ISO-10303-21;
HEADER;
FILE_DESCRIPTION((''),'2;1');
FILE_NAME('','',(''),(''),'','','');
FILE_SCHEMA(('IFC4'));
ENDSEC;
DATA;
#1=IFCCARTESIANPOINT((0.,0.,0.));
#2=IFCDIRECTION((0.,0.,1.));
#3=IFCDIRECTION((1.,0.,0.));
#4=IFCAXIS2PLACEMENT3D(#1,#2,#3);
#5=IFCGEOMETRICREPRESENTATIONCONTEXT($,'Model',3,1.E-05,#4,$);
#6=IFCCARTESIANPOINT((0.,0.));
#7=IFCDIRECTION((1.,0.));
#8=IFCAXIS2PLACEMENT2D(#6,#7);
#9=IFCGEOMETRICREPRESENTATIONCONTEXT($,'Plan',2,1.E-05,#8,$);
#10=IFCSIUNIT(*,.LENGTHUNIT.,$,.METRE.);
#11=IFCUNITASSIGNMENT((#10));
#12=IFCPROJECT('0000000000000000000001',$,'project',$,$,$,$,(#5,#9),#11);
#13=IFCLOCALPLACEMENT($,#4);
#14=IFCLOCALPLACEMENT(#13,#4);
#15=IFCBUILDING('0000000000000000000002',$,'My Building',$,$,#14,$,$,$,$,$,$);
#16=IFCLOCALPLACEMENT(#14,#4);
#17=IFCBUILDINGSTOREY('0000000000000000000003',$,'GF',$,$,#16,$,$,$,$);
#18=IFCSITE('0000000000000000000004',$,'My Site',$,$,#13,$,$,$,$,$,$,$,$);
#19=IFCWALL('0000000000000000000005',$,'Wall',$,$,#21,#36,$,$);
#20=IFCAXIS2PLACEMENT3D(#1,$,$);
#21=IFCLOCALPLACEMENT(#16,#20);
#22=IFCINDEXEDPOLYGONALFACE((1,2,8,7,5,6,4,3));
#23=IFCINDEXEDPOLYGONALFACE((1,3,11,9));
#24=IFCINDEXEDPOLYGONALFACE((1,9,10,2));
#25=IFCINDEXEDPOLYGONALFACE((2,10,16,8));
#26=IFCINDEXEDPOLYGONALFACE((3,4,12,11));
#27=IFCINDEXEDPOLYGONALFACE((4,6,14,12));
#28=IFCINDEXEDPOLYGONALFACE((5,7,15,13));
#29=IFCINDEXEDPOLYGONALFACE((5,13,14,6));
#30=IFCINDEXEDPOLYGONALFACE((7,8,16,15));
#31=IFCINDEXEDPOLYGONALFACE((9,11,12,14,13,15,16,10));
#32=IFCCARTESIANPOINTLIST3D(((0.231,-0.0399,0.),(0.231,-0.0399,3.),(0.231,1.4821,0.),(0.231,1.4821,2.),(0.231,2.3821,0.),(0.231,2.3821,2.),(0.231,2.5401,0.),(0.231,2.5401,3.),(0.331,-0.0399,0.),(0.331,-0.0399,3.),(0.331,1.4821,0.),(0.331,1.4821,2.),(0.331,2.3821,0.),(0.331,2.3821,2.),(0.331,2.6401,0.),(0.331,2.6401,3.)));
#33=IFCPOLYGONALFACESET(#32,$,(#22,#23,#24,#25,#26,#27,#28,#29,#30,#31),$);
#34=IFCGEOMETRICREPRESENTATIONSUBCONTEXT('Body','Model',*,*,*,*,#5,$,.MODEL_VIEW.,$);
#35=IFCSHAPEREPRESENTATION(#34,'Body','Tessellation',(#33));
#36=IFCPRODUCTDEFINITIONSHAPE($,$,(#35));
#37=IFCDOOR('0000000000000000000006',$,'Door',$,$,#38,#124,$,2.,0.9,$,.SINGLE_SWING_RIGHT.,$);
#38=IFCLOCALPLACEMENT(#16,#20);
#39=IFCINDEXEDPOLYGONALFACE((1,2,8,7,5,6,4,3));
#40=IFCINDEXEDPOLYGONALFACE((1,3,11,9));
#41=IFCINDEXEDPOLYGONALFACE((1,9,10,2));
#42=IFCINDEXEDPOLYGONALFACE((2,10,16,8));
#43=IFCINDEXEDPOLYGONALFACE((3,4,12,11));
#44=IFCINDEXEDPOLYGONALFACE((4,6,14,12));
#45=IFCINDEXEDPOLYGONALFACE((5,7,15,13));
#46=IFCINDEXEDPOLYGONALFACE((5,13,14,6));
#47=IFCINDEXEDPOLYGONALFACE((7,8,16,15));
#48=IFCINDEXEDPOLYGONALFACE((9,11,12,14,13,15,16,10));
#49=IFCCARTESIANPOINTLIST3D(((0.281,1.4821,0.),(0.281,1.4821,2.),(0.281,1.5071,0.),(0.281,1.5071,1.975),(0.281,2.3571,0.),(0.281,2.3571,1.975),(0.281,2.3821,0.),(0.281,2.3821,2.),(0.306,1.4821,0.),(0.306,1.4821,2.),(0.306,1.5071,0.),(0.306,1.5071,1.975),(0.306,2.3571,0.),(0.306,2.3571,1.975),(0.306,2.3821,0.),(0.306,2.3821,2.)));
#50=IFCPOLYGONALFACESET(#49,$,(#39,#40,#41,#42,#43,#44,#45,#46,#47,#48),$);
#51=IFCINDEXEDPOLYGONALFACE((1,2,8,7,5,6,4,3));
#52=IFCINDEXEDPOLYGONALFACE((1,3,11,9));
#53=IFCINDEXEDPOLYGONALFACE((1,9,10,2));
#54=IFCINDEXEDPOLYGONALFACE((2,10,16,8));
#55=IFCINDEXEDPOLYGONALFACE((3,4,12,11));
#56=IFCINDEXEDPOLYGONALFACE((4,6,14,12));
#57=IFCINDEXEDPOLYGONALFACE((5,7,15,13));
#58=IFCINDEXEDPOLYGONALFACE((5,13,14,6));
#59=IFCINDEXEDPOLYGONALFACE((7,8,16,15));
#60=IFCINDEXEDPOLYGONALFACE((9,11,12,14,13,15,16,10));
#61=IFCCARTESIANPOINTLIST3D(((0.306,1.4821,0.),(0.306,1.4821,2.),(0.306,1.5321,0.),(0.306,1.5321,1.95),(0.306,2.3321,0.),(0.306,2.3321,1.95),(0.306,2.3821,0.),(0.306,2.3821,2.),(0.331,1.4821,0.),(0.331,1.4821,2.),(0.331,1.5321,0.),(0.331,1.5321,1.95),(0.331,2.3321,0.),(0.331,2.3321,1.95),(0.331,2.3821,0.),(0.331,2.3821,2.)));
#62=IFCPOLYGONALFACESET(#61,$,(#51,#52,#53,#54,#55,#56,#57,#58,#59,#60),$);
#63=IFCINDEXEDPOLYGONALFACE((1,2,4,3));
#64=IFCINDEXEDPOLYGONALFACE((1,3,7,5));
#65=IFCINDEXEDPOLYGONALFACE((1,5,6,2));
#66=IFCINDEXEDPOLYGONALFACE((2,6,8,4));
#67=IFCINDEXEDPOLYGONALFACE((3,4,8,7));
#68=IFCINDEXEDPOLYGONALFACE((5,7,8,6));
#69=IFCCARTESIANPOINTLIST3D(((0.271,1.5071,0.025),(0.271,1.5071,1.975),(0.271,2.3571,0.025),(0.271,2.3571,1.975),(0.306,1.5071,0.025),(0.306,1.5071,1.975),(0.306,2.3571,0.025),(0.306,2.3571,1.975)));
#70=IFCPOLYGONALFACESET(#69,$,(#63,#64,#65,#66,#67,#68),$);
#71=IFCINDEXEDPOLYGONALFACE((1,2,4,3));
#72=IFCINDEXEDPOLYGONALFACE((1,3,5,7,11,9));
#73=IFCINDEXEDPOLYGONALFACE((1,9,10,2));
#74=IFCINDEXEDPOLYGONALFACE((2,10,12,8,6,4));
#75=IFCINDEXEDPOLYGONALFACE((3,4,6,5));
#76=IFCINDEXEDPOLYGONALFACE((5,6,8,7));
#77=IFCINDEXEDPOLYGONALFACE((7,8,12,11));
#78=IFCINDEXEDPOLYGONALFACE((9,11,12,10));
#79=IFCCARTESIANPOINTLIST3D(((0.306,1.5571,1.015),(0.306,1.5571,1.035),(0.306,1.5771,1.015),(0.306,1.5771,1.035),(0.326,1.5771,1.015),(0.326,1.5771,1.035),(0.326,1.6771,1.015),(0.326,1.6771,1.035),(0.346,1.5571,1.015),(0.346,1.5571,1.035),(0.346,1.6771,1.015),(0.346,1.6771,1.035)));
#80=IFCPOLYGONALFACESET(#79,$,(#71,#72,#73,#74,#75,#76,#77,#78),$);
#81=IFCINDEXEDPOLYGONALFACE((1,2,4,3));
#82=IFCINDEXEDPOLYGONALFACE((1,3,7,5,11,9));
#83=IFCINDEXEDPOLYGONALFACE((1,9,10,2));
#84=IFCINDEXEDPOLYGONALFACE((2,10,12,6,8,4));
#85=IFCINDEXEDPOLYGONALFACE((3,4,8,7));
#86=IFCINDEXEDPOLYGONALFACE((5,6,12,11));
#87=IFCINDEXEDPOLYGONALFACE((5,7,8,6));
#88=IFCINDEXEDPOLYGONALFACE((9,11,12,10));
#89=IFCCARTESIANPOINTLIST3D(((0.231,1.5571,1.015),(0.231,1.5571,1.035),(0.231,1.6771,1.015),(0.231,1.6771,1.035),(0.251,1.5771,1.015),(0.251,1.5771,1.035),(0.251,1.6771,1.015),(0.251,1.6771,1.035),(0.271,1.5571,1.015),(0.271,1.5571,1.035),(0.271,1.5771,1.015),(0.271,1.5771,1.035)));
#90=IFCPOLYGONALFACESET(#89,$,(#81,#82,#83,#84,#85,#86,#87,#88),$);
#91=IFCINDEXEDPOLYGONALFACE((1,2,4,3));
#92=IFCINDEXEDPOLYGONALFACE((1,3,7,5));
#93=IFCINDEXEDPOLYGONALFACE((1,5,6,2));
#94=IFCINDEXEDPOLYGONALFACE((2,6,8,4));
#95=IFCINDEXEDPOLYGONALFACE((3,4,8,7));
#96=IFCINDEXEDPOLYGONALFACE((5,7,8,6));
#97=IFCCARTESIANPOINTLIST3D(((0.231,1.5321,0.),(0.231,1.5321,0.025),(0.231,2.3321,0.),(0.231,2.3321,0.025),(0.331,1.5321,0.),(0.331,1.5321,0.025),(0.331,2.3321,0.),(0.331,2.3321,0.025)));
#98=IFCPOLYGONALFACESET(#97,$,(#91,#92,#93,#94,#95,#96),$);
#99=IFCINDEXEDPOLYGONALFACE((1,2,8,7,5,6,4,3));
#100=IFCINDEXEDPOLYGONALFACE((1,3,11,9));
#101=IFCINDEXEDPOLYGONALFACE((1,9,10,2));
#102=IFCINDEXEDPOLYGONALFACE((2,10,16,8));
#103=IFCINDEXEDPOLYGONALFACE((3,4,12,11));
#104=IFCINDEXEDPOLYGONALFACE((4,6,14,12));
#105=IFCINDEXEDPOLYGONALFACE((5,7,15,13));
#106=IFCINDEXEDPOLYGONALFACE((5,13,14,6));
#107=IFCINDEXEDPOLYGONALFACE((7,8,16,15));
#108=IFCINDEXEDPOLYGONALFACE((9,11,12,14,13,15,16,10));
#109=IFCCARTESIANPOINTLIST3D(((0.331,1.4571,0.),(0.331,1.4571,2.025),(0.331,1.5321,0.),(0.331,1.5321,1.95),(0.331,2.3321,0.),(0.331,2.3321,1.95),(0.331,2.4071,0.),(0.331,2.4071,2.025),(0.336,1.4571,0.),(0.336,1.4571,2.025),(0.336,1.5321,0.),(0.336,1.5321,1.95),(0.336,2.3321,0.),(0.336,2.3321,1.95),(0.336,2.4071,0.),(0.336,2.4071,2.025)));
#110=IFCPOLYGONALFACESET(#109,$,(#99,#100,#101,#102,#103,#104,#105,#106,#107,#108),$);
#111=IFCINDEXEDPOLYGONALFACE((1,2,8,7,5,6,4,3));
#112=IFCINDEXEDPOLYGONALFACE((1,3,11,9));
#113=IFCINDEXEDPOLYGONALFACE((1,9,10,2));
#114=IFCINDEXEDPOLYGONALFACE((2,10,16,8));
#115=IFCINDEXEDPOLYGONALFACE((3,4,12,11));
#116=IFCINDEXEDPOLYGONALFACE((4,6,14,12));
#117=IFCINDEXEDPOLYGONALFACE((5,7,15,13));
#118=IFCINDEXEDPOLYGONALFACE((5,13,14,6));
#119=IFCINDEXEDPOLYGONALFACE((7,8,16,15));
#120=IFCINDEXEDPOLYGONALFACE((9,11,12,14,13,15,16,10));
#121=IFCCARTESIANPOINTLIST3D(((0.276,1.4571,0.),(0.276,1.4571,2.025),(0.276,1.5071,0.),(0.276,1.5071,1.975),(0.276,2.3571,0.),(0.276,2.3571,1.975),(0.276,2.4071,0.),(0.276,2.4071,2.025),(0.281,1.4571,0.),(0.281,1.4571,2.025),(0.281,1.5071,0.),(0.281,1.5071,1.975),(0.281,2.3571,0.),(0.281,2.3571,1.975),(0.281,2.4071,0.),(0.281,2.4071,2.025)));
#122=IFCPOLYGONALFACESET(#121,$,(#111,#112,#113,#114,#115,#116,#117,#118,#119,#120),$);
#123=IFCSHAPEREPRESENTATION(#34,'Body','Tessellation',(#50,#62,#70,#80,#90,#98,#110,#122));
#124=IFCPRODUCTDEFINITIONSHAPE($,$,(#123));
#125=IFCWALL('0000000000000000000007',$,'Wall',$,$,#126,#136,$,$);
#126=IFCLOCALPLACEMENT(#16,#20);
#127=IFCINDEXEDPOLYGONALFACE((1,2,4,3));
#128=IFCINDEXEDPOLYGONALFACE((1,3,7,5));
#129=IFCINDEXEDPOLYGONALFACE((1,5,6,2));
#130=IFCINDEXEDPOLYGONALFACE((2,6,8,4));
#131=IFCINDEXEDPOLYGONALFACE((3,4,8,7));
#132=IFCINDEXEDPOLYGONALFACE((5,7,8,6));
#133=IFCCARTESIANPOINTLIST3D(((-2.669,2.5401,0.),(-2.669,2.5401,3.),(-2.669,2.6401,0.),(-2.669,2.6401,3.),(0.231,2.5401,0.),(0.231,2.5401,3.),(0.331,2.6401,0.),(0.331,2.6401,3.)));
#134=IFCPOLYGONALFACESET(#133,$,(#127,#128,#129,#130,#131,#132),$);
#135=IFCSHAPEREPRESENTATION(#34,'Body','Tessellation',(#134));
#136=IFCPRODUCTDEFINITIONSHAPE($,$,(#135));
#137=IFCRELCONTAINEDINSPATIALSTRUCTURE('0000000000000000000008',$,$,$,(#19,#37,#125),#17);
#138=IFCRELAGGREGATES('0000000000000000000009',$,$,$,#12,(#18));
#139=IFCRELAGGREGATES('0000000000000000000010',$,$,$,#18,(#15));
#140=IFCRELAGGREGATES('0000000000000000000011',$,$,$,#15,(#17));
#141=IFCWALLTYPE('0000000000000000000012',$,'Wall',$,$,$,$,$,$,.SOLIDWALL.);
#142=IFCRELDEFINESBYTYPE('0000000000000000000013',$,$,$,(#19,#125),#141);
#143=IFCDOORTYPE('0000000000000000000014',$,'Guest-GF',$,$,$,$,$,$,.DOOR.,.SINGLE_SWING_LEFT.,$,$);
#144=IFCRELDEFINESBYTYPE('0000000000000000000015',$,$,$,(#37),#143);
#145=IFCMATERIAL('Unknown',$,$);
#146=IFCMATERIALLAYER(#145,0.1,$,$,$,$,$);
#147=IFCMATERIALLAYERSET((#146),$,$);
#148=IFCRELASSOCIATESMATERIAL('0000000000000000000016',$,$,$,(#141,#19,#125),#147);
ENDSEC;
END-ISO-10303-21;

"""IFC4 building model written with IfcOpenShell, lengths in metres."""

from ifc_helpers import new_model, entity, si_unit, frame, origin_with_axes, origin_2d_with_axis, place, context, subcontext, project, spatial, line, indexed_curve, outline, extrude, shape, source, transform, mapped, material, layer, layer_set, layer_usage, type_object, type_shapes, element, fill, save


model = new_model("IFC4")

# Units and contexts
model_context = context("Model", 3, precision=1e-05, world=origin_with_axes())
plan_context = context("Plan", 2, precision=1e-05, world=origin_2d_with_axis())
body_context_1 = subcontext(model_context, "Body", "Model", "MODEL_VIEW")
body_context_2 = subcontext(plan_context, "Body", "Plan", "PLAN_VIEW")
ifc_project = project(units=[si_unit("LENGTHUNIT", "METRE")], contexts=[model_context, plan_context])

# Site, building, storey
site_placement = place(None, origin_with_axes())
site = spatial("IfcSite", under=ifc_project, at=site_placement, Name="My Site")
building_placement = place(site_placement, origin_with_axes())
building = spatial("IfcBuilding", under=site, at=building_placement, Name="My Building")
storey_placement = place(building_placement, origin_with_axes())
storey = spatial("IfcBuildingStorey", under=building, at=storey_placement, Name="GF")

# Shared definitions
ifc_material = material(Name="Unknown")

# Shared definitions
ifc_layer_1 = layer(ifc_material, 0.1)
ifc_layer_set_1 = layer_set([ifc_layer_1])
wall_type = type_object("IfcWallType", Name="Wall", PredefinedType="SOLIDWALL", material=ifc_layer_set_1)

# Wall, opening, door
ifc_layer_usage_1 = layer_usage(ifc_layer_set_1, "AXIS2", "POSITIVE", 0.0)
wall_1_placement = place(storey_placement, frame((0.331, -0.0399, 0.0), z_axis=(0.0, 0.0, 1.0), x_axis=(0.0, 1.0, 0.0)))
wall_1 = element("IfcWall", 1, at=wall_1_placement, inside=storey, type_object=wall_type, material=ifc_layer_usage_1, Name="Wall", context=body_context_1, shape_type="SweptSolid", body=[
    extrude(outline(indexed_curve([(0.0, 0.0), (0.0, 0.1), (2.58, 0.1), (2.68, 0.0)], segments=[line(1, 2, 3, 4, 1)])), origin_with_axes(), (0.0, 0.0, 1.0), 3.0),
])
shared_shape_1 = source(origin_with_axes(), body_context_1, "Body", "SweptSolid", [
    extrude(outline(indexed_curve([(0.0, 0.0), (0.9, 0.0), (0.9, 2.0), (0.0, 2.0)], segments=[line(1, 2, 3, 4, 1)])), frame((0.0, -0.6, 0.0), z_axis=(0.0, -1.0, 0.0), x_axis=(1.0, 0.0, 0.0)), (0.0, 0.0, -1.0), 1.2),
])
opening_1_placement = place(wall_1_placement, frame((1.522, 0.0, 0.0), z_axis=(0.0, 0.0, 1.0), x_axis=(1.0, 0.0, 0.0)))
opening_1 = element("IfcOpeningElement", 2, at=opening_1_placement, cuts=wall_1, PredefinedType="OPENING", context=body_context_1, shape_type="MappedRepresentation", body=[
    mapped(shared_shape_1, transform((0.0, 0.0, 0.0), x_axis=(1.0, 0.0, 0.0), y_axis=(0.0, 1.0, 0.0), z_axis=(0.0, 0.0, 1.0), scale=1.0)),
])
door_type_1 = type_object("IfcDoorType", Name="Guest-GF", OperationType="SINGLE_SWING_LEFT", PredefinedType="DOOR")
shared_shape_2 = source(origin_with_axes(), body_context_1, "Body", "SweptSolid", [
    extrude(outline(indexed_curve([(0.0, 0.0), (0.0, 2.0), (0.9, 2.0), (0.9, 0.0), (0.875, 0.0), (0.875, 1.975), (0.025, 1.975), (0.025, 0.0)], segments=[line(1, 2, 3, 4, 5, 6, 7, 8, 1)])), frame((0.0, 0.025, 0.0), z_axis=(0.0, -1.0, 0.0), x_axis=(1.0, 0.0, 0.0)), (0.0, 0.0, -1.0), 0.025),
    extrude(outline(indexed_curve([(0.0, 0.0), (0.0, 2.0), (0.9, 2.0), (0.9, 0.0), (0.85, 0.0), (0.85, 1.95), (0.05, 1.95), (0.05, 0.0)], segments=[line(1, 2, 3, 4, 5, 6, 7, 8, 1)])), frame((0.0, 0.0, 0.0), z_axis=(0.0, -1.0, 0.0), x_axis=(1.0, 0.0, 0.0)), (0.0, 0.0, -1.0), 0.025),
    extrude(outline(indexed_curve([(0.0, 0.0), (0.85, 0.0), (0.85, 0.035), (0.0, 0.035)], segments=[line(1, 2, 3, 4, 1)])), frame((0.025, 0.025, 0.025), z_axis=(0.0, 0.0, 1.0), x_axis=(1.0, 0.0, 0.0)), (0.0, 0.0, 1.0), 1.95),
    extrude(outline(indexed_curve([(0.0, 0.0), (0.0, -0.04), (0.12, -0.04), (0.12, -0.02), (0.02, -0.02), (0.02, 0.0)], segments=[line(1, 2, 3, 4, 5, 6, 1)])), frame((0.075, 0.025, 1.015), z_axis=(0.0, 0.0, 1.0), x_axis=(1.0, 0.0, 0.0)), (0.0, 0.0, 1.0), 0.02),
    extrude(outline(indexed_curve([(0.0, 0.0), (0.0, 0.04), (0.12, 0.04), (0.12, 0.02), (0.02, 0.02), (0.02, 0.0)], segments=[line(1, 2, 3, 4, 5, 6, 1)])), frame((0.075, 0.06, 1.015), z_axis=(0.0, 0.0, 1.0), x_axis=(1.0, 0.0, 0.0)), (0.0, 0.0, 1.0), 0.02),
    extrude(outline(indexed_curve([(0.0, 0.0), (0.8, 0.0), (0.8, 0.1), (0.0, 0.1)], segments=[line(1, 2, 3, 4, 1)])), frame((0.05, 0.0, 0.0), z_axis=(0.0, 0.0, 1.0), x_axis=(1.0, 0.0, 0.0)), (0.0, 0.0, 1.0), 0.025),
    extrude(outline(indexed_curve([(0.0, 0.0), (0.0, 2.025), (0.95, 2.025), (0.95, 0.0), (0.875, 0.0), (0.875, 1.95), (0.075, 1.95), (0.075, 0.0)], segments=[line(1, 2, 3, 4, 5, 6, 7, 8, 1)])), frame((-0.025, -0.005, 0.0), z_axis=(0.0, -1.0, 0.0), x_axis=(1.0, 0.0, 0.0)), (0.0, 0.0, -1.0), 0.005),
    extrude(outline(indexed_curve([(0.0, 0.0), (0.0, 2.025), (0.95, 2.025), (0.95, 0.0), (0.9, 0.0), (0.9, 1.975), (0.05, 1.975), (0.05, 0.0)], segments=[line(1, 2, 3, 4, 5, 6, 7, 8, 1)])), frame((-0.025, 0.05, 0.0), z_axis=(0.0, -1.0, 0.0), x_axis=(1.0, 0.0, 0.0)), (0.0, 0.0, -1.0), 0.005),
])
shared_shape_3 = source(origin_with_axes(), body_context_2, "Body", "Curve2D", [
    entity("IfcIndexedPolyCurve", entity("IfcCartesianPointList2D", [[0.0, 0.0], [0.0, 0.05], [0.025, 0.05], [0.025, 0.025], [0.05, 0.025], [0.05, 0.0]]), [entity("IfcLineIndex", [1, 2, 3, 4, 5, 6, 1])]),
    entity("IfcIndexedPolyCurve", entity("IfcCartesianPointList2D", [[0.9, 0.0], [0.9, 0.05], [0.875, 0.05], [0.875, 0.025], [0.85, 0.025], [0.85, 0.0]]), [entity("IfcLineIndex", [1, 2, 3, 4, 5, 6, 1])]),
    entity("IfcTrimmedCurve", entity("IfcEllipse", entity("IfcAxis2Placement2D", entity("IfcCartesianPoint", [0.84, 0.05]), entity("IfcDirection", [1.0, 0.0])), 0.815, 0.85), [entity("IfcCartesianPoint", [0.84, 0.9])], [entity("IfcCartesianPoint", [0.025, 0.05])], True, "CARTESIAN"),
    entity("IfcIndexedPolyCurve", entity("IfcCartesianPointList2D", [[0.875, 0.05], [0.84, 0.05], [0.84, 0.9], [0.875, 0.9]]), [entity("IfcLineIndex", [1, 2, 3, 4, 1])]),
])
type_shapes(door_type_1, [shared_shape_2, shared_shape_3])
door_1_placement = place(opening_1_placement, frame((0.0, 0.0, 0.0), z_axis=(0.0, 0.0, 1.0), x_axis=(1.0, 0.0, 0.0)))
door_1 = element("IfcDoor", 3, at=door_1_placement, inside=storey, type_object=door_type_1, Name="Door", OperationType="SINGLE_SWING_RIGHT", OverallHeight=2.0, OverallWidth=0.9, shapes=[
    shape(body_context_1, "Body", "MappedRepresentation", [mapped(shared_shape_2, transform((0.0, 0.0, 0.0), x_axis=(1.0, 0.0, 0.0), y_axis=(0.0, 1.0, 0.0), z_axis=(0.0, 0.0, 1.0), scale=1.0))]),
    shape(body_context_2, "Body", "MappedRepresentation", [mapped(shared_shape_3, transform((0.0, 0.0, 0.0), x_axis=(1.0, 0.0, 0.0), y_axis=(0.0, 1.0, 0.0), z_axis=(0.0, 0.0, 1.0), scale=1.0))]),
])
fill(opening_1, door_1)

# Wall
ifc_layer_usage_2 = layer_usage(ifc_layer_set_1, "AXIS2", "POSITIVE", 0.0)
wall_2_placement = place(storey_placement, frame((0.331, 2.6401, 0.0), z_axis=(0.0, 0.0, 1.0), x_axis=(-1.0, 0.0, 0.0)))
element("IfcWall", 4, at=wall_2_placement, inside=storey, type_object=wall_type, material=ifc_layer_usage_2, Name="Wall", context=body_context_1, shape_type="SweptSolid", body=[
    extrude(outline(indexed_curve([(0.0, 0.0), (0.1, 0.1), (3.0, 0.1), (3.0, 0.0)], segments=[line(1, 2, 3, 4, 1)])), origin_with_axes(), (0.0, 0.0, 1.0), 3.0),
])

save(model, "model.ifc")
